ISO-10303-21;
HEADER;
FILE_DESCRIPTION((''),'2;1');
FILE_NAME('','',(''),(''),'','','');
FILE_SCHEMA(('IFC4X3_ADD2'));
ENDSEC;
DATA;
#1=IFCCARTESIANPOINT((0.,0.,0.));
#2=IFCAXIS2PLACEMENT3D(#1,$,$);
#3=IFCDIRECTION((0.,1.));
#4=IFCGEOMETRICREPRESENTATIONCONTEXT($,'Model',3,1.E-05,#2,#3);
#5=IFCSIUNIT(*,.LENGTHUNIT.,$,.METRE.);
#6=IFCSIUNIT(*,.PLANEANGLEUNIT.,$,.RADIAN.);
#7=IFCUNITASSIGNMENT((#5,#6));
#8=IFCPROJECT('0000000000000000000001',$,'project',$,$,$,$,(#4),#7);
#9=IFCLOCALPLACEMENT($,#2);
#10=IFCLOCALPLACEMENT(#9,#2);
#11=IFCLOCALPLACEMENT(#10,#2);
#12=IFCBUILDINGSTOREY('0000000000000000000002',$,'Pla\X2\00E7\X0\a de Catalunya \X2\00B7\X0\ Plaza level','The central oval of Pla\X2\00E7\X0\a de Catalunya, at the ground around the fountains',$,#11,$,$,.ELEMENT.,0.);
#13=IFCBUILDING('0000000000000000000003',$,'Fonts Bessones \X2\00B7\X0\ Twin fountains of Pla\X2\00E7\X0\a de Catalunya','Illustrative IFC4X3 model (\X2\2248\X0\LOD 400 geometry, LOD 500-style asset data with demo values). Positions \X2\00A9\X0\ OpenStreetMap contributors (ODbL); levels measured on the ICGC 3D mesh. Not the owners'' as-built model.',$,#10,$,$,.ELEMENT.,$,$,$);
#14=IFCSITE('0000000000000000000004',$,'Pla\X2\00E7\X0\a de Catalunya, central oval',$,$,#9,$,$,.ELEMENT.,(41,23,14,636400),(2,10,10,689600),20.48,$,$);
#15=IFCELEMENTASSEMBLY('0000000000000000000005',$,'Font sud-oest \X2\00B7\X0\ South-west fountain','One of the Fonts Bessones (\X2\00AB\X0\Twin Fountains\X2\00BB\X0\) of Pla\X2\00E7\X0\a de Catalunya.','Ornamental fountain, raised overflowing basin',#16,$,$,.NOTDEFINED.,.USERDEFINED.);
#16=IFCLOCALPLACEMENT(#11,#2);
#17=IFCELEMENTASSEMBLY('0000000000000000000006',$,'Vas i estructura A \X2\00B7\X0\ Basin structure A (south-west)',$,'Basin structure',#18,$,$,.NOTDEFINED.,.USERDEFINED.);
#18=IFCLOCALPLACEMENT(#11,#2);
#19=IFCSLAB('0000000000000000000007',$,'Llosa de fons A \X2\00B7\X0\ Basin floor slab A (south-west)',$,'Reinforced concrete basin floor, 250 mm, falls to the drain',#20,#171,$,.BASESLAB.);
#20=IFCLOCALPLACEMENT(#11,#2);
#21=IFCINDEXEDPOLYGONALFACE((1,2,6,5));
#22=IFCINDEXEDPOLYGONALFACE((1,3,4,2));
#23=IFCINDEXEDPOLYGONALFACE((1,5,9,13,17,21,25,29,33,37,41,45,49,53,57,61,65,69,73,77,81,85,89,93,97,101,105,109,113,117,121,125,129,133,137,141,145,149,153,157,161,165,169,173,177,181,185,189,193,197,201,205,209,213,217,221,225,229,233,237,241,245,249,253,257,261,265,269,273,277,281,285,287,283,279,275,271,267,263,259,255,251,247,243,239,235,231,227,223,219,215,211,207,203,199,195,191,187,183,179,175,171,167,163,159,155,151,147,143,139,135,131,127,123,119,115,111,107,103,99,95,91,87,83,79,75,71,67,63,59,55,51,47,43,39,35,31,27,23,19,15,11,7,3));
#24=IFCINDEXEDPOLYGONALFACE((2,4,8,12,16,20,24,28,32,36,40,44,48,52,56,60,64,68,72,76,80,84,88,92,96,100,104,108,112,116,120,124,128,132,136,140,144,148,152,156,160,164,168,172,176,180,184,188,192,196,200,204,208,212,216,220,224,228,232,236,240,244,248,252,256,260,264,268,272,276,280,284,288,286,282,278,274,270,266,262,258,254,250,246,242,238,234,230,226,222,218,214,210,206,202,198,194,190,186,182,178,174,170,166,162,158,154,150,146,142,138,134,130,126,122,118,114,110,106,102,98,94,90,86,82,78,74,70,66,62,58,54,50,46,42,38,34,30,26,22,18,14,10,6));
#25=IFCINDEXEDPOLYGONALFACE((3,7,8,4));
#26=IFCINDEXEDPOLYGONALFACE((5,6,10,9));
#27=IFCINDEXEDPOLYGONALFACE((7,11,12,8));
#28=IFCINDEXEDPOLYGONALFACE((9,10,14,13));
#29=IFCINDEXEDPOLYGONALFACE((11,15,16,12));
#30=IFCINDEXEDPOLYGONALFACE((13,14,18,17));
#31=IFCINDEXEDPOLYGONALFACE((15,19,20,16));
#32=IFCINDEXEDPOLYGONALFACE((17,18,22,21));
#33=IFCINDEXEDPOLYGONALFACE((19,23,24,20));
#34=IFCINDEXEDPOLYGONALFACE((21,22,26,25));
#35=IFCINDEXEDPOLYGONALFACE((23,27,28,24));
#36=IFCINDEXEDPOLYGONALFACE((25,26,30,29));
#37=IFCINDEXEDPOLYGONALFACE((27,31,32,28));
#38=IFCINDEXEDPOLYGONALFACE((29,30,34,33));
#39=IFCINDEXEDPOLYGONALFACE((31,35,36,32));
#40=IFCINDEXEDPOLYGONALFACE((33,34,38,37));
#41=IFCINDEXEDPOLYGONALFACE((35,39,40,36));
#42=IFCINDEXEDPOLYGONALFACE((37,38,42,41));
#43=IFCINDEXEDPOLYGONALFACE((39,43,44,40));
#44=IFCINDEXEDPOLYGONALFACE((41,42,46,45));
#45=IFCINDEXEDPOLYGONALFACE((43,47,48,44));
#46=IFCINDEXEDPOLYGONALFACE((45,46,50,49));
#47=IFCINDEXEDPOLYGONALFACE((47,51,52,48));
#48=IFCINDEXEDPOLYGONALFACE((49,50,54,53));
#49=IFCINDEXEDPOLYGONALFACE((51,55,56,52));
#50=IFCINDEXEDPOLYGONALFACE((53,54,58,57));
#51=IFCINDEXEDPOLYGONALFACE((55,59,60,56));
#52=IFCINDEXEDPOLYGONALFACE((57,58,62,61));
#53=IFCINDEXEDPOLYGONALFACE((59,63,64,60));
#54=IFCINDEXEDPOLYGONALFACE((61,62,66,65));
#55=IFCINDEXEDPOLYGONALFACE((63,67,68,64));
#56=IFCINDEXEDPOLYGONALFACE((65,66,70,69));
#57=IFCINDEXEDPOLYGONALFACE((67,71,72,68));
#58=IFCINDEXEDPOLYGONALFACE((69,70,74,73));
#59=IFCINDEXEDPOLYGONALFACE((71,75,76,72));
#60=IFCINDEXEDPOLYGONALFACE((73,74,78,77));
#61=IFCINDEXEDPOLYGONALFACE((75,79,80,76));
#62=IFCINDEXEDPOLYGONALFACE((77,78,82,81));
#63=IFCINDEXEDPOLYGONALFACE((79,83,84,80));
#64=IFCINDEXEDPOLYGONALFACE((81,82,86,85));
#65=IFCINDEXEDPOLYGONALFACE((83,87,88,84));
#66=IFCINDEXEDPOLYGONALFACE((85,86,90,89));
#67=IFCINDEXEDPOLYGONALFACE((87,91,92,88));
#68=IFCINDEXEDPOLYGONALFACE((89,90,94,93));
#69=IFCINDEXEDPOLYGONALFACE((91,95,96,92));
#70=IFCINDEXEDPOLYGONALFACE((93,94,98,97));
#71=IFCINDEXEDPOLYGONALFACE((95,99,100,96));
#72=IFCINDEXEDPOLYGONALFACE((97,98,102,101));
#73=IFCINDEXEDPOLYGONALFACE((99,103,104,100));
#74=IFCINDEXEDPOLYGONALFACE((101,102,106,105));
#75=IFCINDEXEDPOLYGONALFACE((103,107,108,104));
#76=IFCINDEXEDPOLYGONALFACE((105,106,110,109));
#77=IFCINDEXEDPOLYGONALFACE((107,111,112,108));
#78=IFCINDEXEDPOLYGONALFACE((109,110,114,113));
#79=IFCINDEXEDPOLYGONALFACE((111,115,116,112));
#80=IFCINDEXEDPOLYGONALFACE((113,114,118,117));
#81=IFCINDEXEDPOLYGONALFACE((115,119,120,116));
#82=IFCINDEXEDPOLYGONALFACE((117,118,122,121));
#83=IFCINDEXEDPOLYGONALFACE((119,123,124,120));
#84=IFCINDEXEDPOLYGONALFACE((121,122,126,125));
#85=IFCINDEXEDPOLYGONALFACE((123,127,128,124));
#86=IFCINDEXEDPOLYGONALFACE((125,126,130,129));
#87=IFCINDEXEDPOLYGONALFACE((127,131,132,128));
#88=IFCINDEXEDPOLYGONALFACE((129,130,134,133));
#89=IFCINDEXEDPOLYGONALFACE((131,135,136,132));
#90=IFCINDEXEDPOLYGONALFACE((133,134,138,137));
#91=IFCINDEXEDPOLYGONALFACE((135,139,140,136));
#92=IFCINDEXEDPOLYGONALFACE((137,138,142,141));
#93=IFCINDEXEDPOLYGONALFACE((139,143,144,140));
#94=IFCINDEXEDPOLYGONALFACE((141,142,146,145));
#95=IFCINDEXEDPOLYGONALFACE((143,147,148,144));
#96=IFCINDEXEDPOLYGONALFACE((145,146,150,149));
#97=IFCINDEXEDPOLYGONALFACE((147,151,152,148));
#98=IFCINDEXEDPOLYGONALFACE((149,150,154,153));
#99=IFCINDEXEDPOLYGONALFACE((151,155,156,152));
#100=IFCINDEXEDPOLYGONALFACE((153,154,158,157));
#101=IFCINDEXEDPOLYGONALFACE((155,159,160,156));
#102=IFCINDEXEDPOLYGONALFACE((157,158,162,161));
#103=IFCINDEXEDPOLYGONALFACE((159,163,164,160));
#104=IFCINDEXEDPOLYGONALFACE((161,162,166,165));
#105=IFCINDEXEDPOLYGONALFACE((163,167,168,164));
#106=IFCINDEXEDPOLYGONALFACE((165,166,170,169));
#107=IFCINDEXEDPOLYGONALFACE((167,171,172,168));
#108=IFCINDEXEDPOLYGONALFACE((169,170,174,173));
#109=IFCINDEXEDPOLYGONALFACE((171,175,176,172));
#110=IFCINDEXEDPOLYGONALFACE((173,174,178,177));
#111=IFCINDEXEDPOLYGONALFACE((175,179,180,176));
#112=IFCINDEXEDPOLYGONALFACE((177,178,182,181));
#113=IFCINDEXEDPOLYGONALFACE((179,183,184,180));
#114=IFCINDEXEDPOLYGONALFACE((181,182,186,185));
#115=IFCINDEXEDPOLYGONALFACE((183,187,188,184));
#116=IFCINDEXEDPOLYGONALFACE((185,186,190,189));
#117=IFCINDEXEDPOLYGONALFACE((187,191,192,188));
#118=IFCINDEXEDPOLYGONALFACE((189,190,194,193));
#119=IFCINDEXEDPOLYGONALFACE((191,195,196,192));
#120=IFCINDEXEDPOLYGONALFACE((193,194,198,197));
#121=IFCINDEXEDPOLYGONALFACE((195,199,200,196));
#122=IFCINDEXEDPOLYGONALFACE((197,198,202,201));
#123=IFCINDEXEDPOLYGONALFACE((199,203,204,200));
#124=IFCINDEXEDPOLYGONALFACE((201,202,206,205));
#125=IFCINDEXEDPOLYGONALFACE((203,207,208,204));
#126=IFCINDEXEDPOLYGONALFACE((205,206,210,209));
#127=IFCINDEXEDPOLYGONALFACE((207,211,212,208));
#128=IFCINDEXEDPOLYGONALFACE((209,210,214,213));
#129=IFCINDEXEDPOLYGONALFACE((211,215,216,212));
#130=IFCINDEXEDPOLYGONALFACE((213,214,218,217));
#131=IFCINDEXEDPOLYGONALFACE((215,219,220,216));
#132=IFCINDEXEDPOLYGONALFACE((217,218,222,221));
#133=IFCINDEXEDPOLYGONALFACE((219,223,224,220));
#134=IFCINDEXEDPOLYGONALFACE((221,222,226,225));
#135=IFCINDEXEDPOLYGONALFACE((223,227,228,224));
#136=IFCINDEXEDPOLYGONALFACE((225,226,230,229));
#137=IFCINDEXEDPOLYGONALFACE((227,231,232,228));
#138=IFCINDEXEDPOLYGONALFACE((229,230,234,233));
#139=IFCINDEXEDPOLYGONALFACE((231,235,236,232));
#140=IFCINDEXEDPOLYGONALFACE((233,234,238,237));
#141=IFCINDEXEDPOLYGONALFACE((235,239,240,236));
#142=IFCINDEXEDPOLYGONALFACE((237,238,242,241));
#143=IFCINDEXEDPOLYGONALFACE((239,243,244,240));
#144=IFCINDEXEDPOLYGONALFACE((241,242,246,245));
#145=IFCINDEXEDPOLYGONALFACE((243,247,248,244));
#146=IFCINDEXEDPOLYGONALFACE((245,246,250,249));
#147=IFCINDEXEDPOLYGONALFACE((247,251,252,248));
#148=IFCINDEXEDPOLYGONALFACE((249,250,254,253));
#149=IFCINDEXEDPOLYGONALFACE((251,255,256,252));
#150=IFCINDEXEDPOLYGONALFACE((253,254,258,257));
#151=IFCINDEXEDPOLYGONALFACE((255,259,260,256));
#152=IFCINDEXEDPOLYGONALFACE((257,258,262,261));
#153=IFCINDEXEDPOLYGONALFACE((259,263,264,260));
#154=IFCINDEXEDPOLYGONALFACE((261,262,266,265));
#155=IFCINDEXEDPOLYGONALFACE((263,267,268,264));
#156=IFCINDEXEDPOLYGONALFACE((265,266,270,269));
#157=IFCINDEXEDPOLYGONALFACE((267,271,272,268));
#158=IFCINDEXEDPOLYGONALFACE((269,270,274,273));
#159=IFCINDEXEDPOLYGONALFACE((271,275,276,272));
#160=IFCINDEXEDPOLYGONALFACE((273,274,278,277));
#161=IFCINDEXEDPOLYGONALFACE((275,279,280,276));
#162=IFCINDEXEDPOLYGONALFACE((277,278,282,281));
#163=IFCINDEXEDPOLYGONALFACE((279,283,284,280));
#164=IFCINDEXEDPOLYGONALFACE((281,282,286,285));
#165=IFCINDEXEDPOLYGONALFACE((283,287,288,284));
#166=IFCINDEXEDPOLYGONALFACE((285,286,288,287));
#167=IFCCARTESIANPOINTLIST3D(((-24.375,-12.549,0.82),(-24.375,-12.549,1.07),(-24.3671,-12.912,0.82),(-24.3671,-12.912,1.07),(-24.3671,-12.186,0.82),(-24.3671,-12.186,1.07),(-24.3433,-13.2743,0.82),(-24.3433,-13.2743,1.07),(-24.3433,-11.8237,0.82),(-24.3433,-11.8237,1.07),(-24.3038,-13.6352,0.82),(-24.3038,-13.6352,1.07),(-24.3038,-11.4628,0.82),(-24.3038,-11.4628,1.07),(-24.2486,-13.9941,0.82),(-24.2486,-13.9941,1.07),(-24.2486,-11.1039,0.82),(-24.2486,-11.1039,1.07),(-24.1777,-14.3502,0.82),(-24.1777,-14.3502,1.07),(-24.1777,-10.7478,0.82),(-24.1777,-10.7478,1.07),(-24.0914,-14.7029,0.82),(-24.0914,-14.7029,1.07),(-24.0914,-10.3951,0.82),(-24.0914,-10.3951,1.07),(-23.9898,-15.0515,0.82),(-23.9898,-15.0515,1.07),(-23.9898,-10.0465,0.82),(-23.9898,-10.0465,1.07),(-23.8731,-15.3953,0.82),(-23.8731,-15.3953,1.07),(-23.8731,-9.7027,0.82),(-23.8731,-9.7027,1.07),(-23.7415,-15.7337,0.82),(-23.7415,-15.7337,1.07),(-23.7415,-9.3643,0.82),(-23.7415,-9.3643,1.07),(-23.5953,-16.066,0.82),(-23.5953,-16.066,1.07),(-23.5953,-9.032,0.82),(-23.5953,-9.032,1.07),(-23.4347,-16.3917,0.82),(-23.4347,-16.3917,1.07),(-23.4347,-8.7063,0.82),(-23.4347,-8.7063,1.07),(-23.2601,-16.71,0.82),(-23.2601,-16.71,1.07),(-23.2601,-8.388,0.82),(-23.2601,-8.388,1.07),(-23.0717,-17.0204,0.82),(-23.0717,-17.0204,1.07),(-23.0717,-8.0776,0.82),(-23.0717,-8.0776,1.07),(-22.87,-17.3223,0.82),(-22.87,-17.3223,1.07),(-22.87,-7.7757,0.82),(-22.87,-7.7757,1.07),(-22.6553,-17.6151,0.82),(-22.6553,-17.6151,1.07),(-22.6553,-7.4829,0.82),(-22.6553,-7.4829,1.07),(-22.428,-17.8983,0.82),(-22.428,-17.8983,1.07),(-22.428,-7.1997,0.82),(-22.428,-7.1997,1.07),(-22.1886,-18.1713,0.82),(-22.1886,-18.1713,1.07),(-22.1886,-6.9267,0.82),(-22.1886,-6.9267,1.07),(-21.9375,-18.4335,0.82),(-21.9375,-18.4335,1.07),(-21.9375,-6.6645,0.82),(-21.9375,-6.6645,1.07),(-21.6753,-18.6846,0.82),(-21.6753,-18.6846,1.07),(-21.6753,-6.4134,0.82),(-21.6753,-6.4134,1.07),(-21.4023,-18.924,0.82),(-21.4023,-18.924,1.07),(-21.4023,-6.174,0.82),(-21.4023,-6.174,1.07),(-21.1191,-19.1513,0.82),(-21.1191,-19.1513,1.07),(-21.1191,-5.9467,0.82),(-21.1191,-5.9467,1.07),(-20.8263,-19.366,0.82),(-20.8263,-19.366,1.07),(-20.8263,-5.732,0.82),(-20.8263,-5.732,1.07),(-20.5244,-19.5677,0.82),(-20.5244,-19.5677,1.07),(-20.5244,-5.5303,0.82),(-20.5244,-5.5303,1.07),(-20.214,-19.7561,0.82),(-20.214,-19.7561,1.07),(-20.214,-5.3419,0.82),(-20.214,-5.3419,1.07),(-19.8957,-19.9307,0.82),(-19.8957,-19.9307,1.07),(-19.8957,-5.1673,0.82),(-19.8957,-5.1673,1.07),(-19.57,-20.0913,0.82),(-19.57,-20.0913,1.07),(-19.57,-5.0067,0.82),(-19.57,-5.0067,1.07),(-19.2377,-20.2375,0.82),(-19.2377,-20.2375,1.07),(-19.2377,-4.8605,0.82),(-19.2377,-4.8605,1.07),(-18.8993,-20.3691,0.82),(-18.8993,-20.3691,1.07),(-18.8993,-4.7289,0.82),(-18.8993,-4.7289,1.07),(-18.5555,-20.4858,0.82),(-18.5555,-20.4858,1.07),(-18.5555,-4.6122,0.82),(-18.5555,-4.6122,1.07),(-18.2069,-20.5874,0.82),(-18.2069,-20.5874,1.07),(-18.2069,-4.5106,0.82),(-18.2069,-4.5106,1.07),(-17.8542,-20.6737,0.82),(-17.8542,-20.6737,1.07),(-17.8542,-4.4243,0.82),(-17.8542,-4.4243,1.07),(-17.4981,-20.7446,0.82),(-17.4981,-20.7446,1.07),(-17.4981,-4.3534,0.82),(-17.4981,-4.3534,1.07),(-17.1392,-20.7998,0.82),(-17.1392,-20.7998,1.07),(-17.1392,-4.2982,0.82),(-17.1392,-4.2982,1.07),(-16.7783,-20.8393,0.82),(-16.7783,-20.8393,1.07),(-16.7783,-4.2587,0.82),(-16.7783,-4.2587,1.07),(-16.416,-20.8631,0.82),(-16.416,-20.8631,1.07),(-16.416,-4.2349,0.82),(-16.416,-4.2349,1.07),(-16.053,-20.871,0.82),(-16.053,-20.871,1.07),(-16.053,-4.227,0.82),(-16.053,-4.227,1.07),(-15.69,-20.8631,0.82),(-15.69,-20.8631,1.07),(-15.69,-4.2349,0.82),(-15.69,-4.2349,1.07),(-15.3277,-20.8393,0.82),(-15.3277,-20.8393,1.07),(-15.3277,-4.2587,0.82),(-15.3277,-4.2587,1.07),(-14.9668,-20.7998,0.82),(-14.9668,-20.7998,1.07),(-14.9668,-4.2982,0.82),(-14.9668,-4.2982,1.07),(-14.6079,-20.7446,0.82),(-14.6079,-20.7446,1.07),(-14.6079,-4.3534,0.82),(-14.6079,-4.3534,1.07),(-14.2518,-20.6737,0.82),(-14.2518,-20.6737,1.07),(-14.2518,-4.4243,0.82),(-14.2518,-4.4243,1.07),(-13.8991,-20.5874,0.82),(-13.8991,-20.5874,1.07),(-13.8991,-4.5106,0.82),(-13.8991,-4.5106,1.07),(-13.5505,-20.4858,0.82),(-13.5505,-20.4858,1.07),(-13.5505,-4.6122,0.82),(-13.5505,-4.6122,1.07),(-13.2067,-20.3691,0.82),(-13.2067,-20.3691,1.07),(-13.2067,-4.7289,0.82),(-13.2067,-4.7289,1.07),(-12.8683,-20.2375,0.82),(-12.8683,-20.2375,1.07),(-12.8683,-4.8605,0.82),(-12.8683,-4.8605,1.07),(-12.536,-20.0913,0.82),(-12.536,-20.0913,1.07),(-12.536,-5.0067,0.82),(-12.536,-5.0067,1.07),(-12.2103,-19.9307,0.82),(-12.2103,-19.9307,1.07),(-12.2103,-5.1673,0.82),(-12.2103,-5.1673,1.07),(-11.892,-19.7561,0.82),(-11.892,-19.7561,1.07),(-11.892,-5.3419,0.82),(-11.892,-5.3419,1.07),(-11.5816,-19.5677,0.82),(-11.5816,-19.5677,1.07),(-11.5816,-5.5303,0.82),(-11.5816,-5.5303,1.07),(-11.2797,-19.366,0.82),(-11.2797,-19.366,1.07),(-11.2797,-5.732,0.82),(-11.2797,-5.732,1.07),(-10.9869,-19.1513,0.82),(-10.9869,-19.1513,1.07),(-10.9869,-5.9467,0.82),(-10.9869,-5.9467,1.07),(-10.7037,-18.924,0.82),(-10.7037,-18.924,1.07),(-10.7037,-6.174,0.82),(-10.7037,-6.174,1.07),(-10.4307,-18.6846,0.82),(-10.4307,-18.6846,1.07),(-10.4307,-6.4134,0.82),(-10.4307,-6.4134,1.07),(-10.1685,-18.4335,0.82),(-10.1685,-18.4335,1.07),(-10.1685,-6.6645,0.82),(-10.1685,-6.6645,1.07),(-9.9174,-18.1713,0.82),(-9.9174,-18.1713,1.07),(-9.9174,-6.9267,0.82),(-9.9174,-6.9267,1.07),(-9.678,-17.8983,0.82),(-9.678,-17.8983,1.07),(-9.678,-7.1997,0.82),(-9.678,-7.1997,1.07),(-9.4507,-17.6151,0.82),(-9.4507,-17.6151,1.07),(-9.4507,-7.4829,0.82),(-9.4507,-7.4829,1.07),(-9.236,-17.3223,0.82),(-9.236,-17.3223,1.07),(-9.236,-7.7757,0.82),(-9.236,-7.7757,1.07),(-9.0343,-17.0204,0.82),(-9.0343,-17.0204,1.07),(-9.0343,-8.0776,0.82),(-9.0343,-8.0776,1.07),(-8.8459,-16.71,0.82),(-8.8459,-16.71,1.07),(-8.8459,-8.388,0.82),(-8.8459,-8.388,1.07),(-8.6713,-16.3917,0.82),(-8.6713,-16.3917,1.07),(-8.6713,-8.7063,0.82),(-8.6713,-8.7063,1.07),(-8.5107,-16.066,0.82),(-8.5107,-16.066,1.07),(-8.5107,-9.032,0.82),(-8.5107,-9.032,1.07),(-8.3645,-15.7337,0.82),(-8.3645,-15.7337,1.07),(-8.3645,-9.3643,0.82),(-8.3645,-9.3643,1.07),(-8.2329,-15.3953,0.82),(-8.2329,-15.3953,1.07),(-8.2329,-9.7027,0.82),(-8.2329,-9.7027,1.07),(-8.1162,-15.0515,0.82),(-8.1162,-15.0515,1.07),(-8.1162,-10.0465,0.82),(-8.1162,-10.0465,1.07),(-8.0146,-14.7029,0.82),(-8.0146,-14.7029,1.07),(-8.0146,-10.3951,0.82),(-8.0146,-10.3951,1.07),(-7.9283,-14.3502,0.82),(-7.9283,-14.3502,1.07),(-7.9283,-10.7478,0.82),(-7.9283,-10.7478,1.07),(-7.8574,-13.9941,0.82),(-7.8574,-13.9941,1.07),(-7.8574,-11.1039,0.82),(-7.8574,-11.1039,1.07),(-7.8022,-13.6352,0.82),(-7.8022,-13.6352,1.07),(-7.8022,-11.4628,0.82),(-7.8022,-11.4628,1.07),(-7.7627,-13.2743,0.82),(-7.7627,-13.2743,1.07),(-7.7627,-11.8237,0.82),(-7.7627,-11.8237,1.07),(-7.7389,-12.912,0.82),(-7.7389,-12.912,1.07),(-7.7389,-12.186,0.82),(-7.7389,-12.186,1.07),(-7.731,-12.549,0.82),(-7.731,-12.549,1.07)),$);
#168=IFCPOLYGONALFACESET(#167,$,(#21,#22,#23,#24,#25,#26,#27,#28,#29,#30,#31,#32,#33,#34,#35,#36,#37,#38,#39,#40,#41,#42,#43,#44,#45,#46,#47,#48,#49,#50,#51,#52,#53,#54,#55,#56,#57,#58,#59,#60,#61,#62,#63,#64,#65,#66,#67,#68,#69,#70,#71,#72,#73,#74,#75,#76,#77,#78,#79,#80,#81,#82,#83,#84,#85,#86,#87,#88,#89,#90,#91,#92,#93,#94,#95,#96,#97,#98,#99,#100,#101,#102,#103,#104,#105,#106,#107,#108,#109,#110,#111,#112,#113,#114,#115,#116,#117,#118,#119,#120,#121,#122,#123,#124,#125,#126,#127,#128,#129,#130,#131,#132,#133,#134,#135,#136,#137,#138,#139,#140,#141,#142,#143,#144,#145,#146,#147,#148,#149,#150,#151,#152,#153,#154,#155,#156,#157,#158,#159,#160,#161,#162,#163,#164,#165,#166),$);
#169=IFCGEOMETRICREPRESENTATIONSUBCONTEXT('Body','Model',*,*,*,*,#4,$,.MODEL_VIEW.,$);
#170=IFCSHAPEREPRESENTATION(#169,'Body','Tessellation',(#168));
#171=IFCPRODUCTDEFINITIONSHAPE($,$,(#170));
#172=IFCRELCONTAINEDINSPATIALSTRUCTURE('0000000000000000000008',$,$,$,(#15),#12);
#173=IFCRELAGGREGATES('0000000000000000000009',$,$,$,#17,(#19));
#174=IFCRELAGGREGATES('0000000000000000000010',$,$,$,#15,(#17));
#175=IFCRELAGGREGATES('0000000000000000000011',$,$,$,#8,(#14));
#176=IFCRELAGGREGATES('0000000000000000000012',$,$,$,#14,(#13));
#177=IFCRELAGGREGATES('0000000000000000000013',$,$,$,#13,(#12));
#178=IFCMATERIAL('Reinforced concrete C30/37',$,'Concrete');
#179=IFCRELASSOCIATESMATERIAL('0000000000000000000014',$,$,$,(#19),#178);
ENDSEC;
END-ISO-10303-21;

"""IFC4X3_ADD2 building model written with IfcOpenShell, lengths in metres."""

from ifc_helpers import new_model, si_unit, direction, frame, origin, origin_2d_with_axis, place, context, subcontext, project, spatial, circle, extrude, material, element, aggregate, save


model = new_model("IFC4X3_ADD2")

# Units and contexts
model_context = context("Model", 3, precision=1e-05, world=origin(), true_north=direction((0.0, 1.0)))
body_context = subcontext(model_context, "Body", "Model", "MODEL_VIEW")
ifc_project = project(units=[si_unit("LENGTHUNIT", "METRE"), si_unit("PLANEANGLEUNIT", "RADIAN")], contexts=[model_context])

# Site, building, storey
site_placement = place(None, origin())
site = spatial("IfcSite", under=ifc_project, at=site_placement, Name="Plaça de Catalunya, central oval", CompositionType="ELEMENT", RefLatitude=(41, 23, 14, 636400), RefLongitude=(2, 10, 10, 689600), RefElevation=20.48)
building_placement = place(site_placement, origin())
building = spatial("IfcBuilding", under=site, at=building_placement, Name="Fonts Bessones · Twin fountains of Plaça de Catalunya", Description="Illustrative IFC4X3 model (≈LOD 400 geometry, LOD 500-style asset data with demo values). Positions © OpenStreetMap contributors (ODbL); levels measured on the ICGC 3D mesh. Not the owners' as-built model.", CompositionType="ELEMENT")
storey_placement = place(building_placement, origin())
storey = spatial("IfcBuildingStorey", under=building, at=storey_placement, Name="Plaça de Catalunya · Plaza level", Description="The central oval of Plaça de Catalunya, at the ground around the fountains", CompositionType="ELEMENT", Elevation=0.0)

# Element assemblies, slab
assembly_1_placement = place(building_placement, origin())
assembly_1 = element("IfcElementAssembly", 1, at=assembly_1_placement, inside=storey, Name="Font sud-oest · South-west fountain", Description="One of the Fonts Bessones («Twin Fountains») of Plaça de Catalunya.", ObjectType="Ornamental fountain, raised overflowing basin", AssemblyPlace="NOTDEFINED", PredefinedType="USERDEFINED")
assembly_2_placement = place(building_placement, origin())
assembly_2 = element("IfcElementAssembly", 2, at=assembly_2_placement, Name="Vas i estructura A · Basin structure A (south-west)", ObjectType="Basin structure", AssemblyPlace="NOTDEFINED", PredefinedType="USERDEFINED")
ifc_material_1 = material(Name="Reinforced concrete C30/37", Category="Concrete")
slab_1_placement = place(building_placement, origin())
slab_1 = element("IfcSlab", 3, at=slab_1_placement, material=ifc_material_1, Name="Llosa de fons A · Basin floor slab A (south-west)", ObjectType="Reinforced concrete basin floor, 250 mm, falls to the drain", PredefinedType="BASESLAB", context=body_context, shape_type="SweptSolid", body=[
    extrude(circle(Radius=8.322, at=origin_2d_with_axis()), frame((-16.053, -12.549, 0.82)), (0.0, 0.0, 1.0), 0.25),
])
aggregate(assembly_2, [slab_1])
aggregate(assembly_1, [assembly_2])

save(model, "model.ifc")
